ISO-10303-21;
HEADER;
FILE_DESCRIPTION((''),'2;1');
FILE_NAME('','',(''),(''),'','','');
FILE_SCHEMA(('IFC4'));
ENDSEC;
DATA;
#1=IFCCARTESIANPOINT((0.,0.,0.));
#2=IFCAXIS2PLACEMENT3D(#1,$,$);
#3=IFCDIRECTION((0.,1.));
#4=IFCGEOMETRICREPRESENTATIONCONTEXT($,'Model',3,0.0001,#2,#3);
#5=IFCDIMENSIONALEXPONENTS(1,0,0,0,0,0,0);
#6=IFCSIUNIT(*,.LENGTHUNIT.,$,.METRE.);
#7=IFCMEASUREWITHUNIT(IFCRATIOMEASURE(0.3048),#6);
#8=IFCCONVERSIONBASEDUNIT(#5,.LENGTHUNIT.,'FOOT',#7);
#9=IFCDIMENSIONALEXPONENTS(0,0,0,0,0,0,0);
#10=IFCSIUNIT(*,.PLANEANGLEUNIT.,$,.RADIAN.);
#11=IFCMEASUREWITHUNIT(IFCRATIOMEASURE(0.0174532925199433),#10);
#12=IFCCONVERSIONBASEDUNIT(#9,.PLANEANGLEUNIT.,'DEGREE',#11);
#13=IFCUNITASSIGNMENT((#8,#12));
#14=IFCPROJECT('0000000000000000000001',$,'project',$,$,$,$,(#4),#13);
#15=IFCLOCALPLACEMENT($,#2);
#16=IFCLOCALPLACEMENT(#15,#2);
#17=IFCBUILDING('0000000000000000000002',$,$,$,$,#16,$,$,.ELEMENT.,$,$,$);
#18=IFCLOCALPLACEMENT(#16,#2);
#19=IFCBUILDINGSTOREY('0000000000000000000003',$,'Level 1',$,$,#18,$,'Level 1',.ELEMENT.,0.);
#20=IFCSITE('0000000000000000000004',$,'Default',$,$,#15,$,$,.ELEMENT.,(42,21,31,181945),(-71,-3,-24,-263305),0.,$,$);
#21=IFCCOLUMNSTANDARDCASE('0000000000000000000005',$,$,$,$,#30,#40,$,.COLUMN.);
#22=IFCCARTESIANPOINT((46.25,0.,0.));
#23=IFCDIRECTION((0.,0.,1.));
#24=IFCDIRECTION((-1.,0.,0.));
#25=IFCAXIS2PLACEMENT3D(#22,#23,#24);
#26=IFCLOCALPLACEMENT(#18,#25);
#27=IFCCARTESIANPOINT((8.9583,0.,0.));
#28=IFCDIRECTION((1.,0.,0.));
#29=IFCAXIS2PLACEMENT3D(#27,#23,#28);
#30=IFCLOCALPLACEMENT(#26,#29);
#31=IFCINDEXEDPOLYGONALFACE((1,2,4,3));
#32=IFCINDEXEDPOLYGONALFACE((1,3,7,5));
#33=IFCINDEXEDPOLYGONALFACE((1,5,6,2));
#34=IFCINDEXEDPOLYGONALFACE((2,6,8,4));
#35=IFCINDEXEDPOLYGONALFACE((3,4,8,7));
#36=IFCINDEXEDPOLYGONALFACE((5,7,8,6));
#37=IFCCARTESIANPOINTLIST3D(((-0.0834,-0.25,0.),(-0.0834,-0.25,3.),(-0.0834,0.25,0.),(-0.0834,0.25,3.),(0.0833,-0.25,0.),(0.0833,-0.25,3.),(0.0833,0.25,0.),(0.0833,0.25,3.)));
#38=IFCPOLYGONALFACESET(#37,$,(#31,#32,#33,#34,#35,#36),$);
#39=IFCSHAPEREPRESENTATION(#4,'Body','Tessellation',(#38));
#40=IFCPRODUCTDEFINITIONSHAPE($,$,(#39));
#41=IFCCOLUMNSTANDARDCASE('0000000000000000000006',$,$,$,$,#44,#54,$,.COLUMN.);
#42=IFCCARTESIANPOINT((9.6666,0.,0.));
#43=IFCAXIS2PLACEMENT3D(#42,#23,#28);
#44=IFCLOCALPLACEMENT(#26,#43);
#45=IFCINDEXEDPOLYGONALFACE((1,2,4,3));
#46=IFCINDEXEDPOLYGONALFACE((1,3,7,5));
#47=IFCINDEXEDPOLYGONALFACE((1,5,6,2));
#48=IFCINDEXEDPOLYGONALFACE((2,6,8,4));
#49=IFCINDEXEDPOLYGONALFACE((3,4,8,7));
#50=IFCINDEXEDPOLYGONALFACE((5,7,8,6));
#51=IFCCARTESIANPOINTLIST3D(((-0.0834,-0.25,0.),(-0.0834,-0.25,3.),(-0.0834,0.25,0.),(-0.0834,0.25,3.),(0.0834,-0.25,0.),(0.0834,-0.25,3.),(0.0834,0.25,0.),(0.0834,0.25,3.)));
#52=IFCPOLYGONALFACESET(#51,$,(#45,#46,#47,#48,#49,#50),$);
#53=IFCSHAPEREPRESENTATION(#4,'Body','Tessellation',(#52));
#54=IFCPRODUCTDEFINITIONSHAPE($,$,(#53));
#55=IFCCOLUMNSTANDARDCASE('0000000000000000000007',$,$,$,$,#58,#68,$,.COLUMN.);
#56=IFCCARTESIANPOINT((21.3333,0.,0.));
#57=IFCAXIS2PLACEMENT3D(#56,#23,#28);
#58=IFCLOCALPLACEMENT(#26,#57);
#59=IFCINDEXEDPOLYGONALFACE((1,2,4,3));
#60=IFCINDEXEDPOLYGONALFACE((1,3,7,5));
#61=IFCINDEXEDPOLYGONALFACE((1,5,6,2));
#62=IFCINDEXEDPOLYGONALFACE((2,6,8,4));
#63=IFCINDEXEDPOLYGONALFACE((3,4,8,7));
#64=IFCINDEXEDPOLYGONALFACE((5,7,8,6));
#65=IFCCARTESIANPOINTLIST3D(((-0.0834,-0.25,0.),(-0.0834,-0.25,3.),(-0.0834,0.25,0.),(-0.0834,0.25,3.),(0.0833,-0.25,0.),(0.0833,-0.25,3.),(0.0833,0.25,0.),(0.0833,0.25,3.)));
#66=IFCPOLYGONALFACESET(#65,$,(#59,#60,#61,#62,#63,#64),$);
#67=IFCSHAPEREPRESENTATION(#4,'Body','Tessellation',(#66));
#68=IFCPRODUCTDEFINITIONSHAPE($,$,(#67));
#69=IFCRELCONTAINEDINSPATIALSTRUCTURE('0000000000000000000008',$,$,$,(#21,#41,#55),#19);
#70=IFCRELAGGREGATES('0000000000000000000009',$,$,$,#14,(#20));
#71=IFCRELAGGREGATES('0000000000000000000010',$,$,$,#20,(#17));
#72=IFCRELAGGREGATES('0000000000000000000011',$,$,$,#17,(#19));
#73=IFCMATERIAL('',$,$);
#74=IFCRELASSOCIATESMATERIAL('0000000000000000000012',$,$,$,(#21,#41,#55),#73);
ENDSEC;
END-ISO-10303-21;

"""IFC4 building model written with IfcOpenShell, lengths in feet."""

from ifc_helpers import new_model, entity, si_unit, converted_unit, direction, frame, origin, place, context, project, spatial, rectangle, extrude, material, element, save


model = new_model("IFC4")

# Units and contexts
model_context = context("Model", 3, precision=0.0001, world=origin(), true_north=direction((0.0, 1.0)))
ifc_project = project(units=[converted_unit("LENGTHUNIT", "FOOT", entity("IfcRatioMeasure", 0.3048), si_unit("LENGTHUNIT", "METRE"), dimensions=[1, 0, 0, 0, 0, 0, 0]), converted_unit("PLANEANGLEUNIT", "DEGREE", entity("IfcRatioMeasure", 0.0174532925199433), si_unit("PLANEANGLEUNIT", "RADIAN"), dimensions=[0, 0, 0, 0, 0, 0, 0])], contexts=[model_context])

# Site, building, storey
site_placement = place(None, origin())
site = spatial("IfcSite", under=ifc_project, at=site_placement, Name="Default", CompositionType="ELEMENT", RefLatitude=(42, 21, 31, 181945), RefLongitude=(-71, -3, -24, -263305), RefElevation=0.0)
building_placement = place(site_placement, origin())
building = spatial("IfcBuilding", under=site, at=building_placement, CompositionType="ELEMENT")
storey_placement = place(building_placement, origin())
storey = spatial("IfcBuildingStorey", under=building, at=storey_placement, Name="Level 1", LongName="Level 1", CompositionType="ELEMENT", Elevation=0.0)

# Columns
placement = place(storey_placement, frame((46.25, 0.0, 0.0), z_axis=(0.0, 0.0, 1.0), x_axis=(-1.0, 0.0, 0.0)))
ifc_material_1 = material(Name="")
for number, where, z_axis, x_axis in (
    (1, (8.9583, 0.0, 0.0), (0.0, 0.0, 1.0), (1.0, 0.0, 0.0)),
    (2, (9.6666, 0.0, 0.0), (0.0, 0.0, 1.0), (1.0, 0.0, 0.0)),
    (3, (21.3333, 0.0, 0.0), (0.0, 0.0, 1.0), (1.0, 0.0, 0.0)),
):
    element("IfcColumnStandardCase", number, at=place(placement, frame(where, z_axis=z_axis, x_axis=x_axis)), inside=storey, material=ifc_material_1, PredefinedType="COLUMN", context=model_context, shape_type="SweptSolid", body=[
        extrude(rectangle(XDim=0.1667, YDim=0.5), origin(), (0.0, 0.0, 1.0), 3.0),
    ])

save(model, "model.ifc")
